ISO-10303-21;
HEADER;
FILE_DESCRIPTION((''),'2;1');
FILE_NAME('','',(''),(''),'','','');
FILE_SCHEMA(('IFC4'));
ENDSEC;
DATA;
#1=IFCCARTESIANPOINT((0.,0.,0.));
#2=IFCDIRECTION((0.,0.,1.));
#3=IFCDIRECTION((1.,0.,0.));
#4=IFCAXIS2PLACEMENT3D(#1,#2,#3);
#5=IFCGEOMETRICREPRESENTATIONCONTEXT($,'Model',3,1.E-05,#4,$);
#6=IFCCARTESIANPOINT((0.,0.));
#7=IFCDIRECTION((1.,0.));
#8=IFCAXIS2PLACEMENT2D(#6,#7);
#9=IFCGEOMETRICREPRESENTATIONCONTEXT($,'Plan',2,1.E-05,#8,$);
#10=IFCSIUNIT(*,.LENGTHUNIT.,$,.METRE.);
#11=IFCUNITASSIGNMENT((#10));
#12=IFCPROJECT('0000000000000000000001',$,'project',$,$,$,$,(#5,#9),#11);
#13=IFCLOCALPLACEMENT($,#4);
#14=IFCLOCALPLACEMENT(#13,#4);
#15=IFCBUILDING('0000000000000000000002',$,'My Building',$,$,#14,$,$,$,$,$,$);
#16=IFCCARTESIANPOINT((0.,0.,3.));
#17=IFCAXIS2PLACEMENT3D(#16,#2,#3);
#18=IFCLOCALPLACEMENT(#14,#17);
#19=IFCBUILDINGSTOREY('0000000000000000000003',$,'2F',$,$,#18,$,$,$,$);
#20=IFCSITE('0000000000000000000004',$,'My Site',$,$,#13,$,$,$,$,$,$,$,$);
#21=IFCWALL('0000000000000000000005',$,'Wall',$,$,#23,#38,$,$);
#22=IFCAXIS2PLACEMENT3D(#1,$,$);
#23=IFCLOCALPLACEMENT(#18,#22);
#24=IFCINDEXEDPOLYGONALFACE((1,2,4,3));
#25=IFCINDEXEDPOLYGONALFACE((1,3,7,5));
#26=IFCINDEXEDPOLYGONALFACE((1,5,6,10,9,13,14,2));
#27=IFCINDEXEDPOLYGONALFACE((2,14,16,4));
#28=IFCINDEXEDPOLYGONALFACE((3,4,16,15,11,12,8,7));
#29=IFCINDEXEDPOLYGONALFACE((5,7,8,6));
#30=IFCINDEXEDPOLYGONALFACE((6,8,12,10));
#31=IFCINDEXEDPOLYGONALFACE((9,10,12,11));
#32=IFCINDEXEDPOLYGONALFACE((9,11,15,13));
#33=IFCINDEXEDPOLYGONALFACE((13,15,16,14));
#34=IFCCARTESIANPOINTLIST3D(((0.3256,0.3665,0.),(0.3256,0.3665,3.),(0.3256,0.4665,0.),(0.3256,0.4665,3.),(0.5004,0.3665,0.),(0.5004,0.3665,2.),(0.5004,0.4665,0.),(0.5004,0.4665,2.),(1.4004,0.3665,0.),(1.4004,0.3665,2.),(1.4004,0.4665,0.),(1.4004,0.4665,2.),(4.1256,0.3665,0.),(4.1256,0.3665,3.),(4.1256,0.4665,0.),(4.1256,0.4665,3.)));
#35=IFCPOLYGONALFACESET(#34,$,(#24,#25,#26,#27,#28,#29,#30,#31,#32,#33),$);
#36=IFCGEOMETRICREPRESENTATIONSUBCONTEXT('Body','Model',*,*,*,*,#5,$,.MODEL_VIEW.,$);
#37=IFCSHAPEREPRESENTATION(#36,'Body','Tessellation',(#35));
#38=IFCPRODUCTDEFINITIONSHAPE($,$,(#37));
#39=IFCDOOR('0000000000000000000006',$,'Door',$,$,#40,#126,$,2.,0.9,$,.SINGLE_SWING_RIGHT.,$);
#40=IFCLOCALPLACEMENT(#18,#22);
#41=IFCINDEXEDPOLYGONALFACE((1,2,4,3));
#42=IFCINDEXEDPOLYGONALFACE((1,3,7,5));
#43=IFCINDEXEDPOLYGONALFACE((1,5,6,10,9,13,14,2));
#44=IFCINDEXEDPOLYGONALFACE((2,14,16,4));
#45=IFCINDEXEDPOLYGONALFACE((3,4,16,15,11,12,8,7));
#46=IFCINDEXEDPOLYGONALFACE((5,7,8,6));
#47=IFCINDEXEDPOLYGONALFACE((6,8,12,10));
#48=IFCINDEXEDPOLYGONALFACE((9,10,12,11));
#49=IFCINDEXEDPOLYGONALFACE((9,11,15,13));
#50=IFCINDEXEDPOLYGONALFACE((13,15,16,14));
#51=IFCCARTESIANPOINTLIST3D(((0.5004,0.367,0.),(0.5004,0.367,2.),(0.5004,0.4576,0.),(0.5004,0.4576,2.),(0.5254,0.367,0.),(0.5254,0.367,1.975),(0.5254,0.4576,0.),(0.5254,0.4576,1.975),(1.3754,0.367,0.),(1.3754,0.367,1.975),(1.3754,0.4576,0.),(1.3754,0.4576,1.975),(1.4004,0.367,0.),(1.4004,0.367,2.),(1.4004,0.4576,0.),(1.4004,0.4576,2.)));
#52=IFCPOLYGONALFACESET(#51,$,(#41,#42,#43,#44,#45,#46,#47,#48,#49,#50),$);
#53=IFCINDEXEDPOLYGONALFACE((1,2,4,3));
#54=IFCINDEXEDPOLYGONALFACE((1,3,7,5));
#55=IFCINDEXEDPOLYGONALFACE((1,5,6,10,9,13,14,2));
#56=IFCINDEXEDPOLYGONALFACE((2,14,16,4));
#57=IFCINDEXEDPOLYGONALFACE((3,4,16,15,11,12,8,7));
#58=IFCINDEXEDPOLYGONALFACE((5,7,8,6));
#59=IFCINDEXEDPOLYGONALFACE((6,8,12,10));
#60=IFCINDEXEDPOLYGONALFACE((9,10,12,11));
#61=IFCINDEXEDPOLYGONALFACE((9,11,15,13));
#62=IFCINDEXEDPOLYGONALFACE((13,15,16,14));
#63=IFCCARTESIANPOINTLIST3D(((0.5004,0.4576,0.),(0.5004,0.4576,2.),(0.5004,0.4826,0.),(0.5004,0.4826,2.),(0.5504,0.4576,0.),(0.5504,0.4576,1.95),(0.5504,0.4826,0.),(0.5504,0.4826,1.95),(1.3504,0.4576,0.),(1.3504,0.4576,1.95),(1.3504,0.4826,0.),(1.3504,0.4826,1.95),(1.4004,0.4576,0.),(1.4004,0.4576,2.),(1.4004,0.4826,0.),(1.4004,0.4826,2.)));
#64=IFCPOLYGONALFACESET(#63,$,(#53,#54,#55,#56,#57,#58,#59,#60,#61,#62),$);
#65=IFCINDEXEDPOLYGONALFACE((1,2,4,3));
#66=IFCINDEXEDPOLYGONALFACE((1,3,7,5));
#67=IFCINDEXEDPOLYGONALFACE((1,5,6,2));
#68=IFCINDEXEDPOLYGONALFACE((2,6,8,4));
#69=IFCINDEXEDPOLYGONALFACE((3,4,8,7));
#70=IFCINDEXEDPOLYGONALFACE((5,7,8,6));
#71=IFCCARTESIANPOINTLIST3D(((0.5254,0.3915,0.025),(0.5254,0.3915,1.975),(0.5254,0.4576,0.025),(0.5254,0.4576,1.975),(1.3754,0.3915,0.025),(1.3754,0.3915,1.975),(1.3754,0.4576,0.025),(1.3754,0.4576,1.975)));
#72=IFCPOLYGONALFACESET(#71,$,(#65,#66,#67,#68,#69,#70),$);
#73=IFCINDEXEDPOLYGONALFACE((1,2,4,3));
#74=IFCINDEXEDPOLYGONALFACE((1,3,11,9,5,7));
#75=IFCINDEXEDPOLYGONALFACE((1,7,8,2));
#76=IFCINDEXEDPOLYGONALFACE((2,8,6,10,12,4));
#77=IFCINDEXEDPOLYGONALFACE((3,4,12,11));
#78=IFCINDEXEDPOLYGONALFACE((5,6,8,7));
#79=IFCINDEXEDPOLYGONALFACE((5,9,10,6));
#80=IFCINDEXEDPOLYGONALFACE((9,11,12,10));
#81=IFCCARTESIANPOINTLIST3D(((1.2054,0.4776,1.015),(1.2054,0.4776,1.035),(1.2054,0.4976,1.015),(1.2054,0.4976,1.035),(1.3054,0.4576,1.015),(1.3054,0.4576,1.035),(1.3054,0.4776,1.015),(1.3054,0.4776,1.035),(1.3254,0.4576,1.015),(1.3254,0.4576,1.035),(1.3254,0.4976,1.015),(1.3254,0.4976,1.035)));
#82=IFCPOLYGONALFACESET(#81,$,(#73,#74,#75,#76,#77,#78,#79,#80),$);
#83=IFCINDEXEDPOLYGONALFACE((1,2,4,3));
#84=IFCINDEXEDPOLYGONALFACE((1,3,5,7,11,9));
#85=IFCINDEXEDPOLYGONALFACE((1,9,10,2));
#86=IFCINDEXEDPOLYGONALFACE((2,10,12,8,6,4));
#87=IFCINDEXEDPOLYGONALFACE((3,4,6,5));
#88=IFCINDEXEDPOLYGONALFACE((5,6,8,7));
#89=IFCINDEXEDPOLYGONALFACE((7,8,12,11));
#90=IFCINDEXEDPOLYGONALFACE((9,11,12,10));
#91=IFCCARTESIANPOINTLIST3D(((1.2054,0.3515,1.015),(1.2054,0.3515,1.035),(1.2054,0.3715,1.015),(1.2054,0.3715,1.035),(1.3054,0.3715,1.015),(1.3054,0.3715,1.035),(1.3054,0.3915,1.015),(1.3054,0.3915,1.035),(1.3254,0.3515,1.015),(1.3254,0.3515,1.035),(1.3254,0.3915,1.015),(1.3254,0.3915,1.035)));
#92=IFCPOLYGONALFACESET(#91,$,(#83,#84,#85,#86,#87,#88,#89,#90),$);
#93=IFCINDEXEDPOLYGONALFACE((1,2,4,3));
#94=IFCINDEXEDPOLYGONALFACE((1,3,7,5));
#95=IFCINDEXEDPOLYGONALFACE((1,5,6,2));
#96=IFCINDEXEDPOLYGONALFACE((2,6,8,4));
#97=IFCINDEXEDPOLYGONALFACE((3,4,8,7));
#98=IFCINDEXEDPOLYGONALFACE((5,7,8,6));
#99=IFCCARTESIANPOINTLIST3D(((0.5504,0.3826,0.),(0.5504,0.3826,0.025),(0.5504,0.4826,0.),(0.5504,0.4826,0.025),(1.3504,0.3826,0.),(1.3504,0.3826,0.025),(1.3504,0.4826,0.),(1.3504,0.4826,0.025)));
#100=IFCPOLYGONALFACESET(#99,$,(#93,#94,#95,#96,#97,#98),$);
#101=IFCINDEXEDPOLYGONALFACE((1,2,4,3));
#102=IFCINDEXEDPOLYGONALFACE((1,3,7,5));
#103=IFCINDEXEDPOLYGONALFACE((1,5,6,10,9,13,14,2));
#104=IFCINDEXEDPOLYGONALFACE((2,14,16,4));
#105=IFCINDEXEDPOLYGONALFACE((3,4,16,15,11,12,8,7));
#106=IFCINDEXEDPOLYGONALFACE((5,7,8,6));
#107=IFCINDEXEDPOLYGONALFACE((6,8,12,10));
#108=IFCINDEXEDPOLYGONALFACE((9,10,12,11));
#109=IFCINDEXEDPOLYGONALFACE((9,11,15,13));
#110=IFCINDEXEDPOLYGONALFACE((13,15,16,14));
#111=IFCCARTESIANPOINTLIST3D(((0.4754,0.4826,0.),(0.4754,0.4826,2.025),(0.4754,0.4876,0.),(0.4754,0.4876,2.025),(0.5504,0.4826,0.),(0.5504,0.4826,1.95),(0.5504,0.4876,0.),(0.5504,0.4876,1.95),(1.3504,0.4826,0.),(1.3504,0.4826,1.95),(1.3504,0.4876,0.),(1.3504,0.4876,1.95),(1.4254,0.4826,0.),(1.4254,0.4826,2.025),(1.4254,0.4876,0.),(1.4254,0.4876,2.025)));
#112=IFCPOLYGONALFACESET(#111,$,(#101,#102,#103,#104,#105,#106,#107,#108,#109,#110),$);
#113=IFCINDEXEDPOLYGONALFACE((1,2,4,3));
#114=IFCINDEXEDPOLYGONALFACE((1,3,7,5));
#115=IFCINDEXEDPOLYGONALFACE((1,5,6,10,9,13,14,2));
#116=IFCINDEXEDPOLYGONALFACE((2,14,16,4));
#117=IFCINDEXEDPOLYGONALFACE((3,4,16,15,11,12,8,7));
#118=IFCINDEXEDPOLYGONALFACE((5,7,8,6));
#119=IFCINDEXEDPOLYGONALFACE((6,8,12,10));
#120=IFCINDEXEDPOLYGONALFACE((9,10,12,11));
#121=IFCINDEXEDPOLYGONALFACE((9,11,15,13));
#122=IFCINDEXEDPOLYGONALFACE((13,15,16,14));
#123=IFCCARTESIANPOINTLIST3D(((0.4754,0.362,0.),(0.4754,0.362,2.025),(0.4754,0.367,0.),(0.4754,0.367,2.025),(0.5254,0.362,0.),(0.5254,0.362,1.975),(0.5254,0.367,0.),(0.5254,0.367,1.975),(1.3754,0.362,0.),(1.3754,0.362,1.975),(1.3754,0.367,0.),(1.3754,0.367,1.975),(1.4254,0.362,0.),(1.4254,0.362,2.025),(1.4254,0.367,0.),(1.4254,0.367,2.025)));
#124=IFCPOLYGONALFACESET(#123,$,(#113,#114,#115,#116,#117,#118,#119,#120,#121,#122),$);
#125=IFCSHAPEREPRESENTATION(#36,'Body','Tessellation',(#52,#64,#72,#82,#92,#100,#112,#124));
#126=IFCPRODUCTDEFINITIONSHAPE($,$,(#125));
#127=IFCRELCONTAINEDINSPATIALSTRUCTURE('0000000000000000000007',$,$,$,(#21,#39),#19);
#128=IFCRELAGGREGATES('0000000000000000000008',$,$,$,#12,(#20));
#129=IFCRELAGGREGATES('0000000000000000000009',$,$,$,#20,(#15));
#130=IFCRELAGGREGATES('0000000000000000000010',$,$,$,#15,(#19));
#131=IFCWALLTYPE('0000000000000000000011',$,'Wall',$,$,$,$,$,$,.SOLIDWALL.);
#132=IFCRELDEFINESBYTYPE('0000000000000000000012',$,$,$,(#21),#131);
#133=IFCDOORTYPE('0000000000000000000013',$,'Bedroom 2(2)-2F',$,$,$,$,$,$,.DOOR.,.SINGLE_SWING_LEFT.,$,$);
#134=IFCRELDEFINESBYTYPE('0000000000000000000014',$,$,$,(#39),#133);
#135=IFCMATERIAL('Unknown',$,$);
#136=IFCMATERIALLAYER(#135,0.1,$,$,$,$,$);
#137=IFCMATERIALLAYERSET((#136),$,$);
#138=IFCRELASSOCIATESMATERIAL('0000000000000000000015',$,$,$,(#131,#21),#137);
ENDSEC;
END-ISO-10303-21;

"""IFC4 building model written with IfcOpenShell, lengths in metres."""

from ifc_helpers import new_model, entity, si_unit, frame, origin_with_axes, origin_2d_with_axis, place, context, subcontext, project, spatial, line, indexed_curve, outline, extrude, shape, source, transform, mapped, material, layer, layer_set, layer_usage, type_object, type_shapes, element, fill, save


model = new_model("IFC4")

# Units and contexts
model_context = context("Model", 3, precision=1e-05, world=origin_with_axes())
plan_context = context("Plan", 2, precision=1e-05, world=origin_2d_with_axis())
body_context_1 = subcontext(model_context, "Body", "Model", "MODEL_VIEW")
body_context_2 = subcontext(plan_context, "Body", "Plan", "PLAN_VIEW")
ifc_project = project(units=[si_unit("LENGTHUNIT", "METRE")], contexts=[model_context, plan_context])

# Site, building, storey
site_placement = place(None, origin_with_axes())
site = spatial("IfcSite", under=ifc_project, at=site_placement, Name="My Site")
building_placement = place(site_placement, origin_with_axes())
building = spatial("IfcBuilding", under=site, at=building_placement, Name="My Building")
storey_placement = place(building_placement, frame((0.0, 0.0, 3.0), z_axis=(0.0, 0.0, 1.0), x_axis=(1.0, 0.0, 0.0)))
storey = spatial("IfcBuildingStorey", under=building, at=storey_placement, Name="2F")

# Shared definitions
ifc_material = material(Name="Unknown")

# Shared definitions
ifc_layer_1 = layer(ifc_material, 0.1)
ifc_layer_set_1 = layer_set([ifc_layer_1])
wall_type = type_object("IfcWallType", Name="Wall", PredefinedType="SOLIDWALL", material=ifc_layer_set_1)

# Wall, opening, door
ifc_layer_usage_1 = layer_usage(ifc_layer_set_1, "AXIS2", "POSITIVE", 0.0)
wall_1_placement = place(storey_placement, frame((4.1256, 0.4665, 0.0), z_axis=(0.0, 0.0, 1.0), x_axis=(-1.0, 0.0, 0.0)))
wall_1 = element("IfcWall", 1, at=wall_1_placement, inside=storey, type_object=wall_type, material=ifc_layer_usage_1, Name="Wall", context=body_context_1, shape_type="SweptSolid", body=[
    extrude(outline(indexed_curve([(0.0, 0.0), (0.0, 0.1), (3.8, 0.1), (3.8, 0.0)], segments=[line(1, 2, 3, 4, 1)])), origin_with_axes(), (0.0, 0.0, 1.0), 3.0),
])
shared_shape_1 = source(origin_with_axes(), body_context_1, "Body", "SweptSolid", [
    extrude(outline(indexed_curve([(0.0, 0.0), (0.9, 0.0), (0.9, 2.0), (0.0, 2.0)], segments=[line(1, 2, 3, 4, 1)])), frame((0.0, -0.6, 0.0), z_axis=(0.0, -1.0, 0.0), x_axis=(1.0, 0.0, 0.0)), (0.0, 0.0, -1.0), 1.2),
])
opening_1_placement = place(wall_1_placement, frame((2.7252, -0.0161, 0.0), z_axis=(0.0, 0.0, 1.0), x_axis=(1.0, 0.0, 0.0)))
opening_1 = element("IfcOpeningElement", 2, at=opening_1_placement, cuts=wall_1, PredefinedType="OPENING", context=body_context_1, shape_type="MappedRepresentation", body=[
    mapped(shared_shape_1, transform((0.0, 0.0, 0.0), x_axis=(1.0, 0.0, 0.0), y_axis=(0.0, 1.0, 0.0), z_axis=(0.0, 0.0, 1.0), scale=1.0)),
])
door_type_1 = type_object("IfcDoorType", Name="Bedroom 2(2)-2F", OperationType="SINGLE_SWING_LEFT", PredefinedType="DOOR")
shared_shape_2 = source(origin_with_axes(), body_context_1, "Body", "SweptSolid", [
    extrude(outline(indexed_curve([(0.0, 0.0), (0.0, 2.0), (0.9, 2.0), (0.9, 0.0), (0.875, 0.0), (0.875, 1.975), (0.025, 1.975), (0.025, 0.0)], segments=[line(1, 2, 3, 4, 5, 6, 7, 8, 1)])), frame((0.0, 0.025, 0.0), z_axis=(0.0, -1.0, 0.0), x_axis=(1.0, 0.0, 0.0)), (0.0, 0.0, -1.0), 0.0906),
    extrude(outline(indexed_curve([(0.0, 0.0), (0.0, 2.0), (0.9, 2.0), (0.9, 0.0), (0.85, 0.0), (0.85, 1.95), (0.05, 1.95), (0.05, 0.0)], segments=[line(1, 2, 3, 4, 5, 6, 7, 8, 1)])), frame((0.0, 0.0, 0.0), z_axis=(0.0, -1.0, 0.0), x_axis=(1.0, 0.0, 0.0)), (0.0, 0.0, -1.0), 0.025),
    extrude(outline(indexed_curve([(0.0, 0.0), (0.85, 0.0), (0.85, 0.0661), (0.0, 0.0661)], segments=[line(1, 2, 3, 4, 1)])), frame((0.025, 0.025, 0.025), z_axis=(0.0, 0.0, 1.0), x_axis=(1.0, 0.0, 0.0)), (0.0, 0.0, 1.0), 1.95),
    extrude(outline(indexed_curve([(0.0, 0.0), (0.0, -0.04), (0.12, -0.04), (0.12, -0.02), (0.02, -0.02), (0.02, 0.0)], segments=[line(1, 2, 3, 4, 5, 6, 1)])), frame((0.075, 0.025, 1.015), z_axis=(0.0, 0.0, 1.0), x_axis=(1.0, 0.0, 0.0)), (0.0, 0.0, 1.0), 0.02),
    extrude(outline(indexed_curve([(0.0, 0.0), (0.0, 0.04), (0.12, 0.04), (0.12, 0.02), (0.02, 0.02), (0.02, 0.0)], segments=[line(1, 2, 3, 4, 5, 6, 1)])), frame((0.075, 0.0911, 1.015), z_axis=(0.0, 0.0, 1.0), x_axis=(1.0, 0.0, 0.0)), (0.0, 0.0, 1.0), 0.02),
    extrude(outline(indexed_curve([(0.0, 0.0), (0.8, 0.0), (0.8, 0.1), (0.0, 0.1)], segments=[line(1, 2, 3, 4, 1)])), frame((0.05, 0.0, 0.0), z_axis=(0.0, 0.0, 1.0), x_axis=(1.0, 0.0, 0.0)), (0.0, 0.0, 1.0), 0.025),
    extrude(outline(indexed_curve([(0.0, 0.0), (0.0, 2.025), (0.95, 2.025), (0.95, 0.0), (0.875, 0.0), (0.875, 1.95), (0.075, 1.95), (0.075, 0.0)], segments=[line(1, 2, 3, 4, 5, 6, 7, 8, 1)])), frame((-0.025, -0.005, 0.0), z_axis=(0.0, -1.0, 0.0), x_axis=(1.0, 0.0, 0.0)), (0.0, 0.0, -1.0), 0.005),
    extrude(outline(indexed_curve([(0.0, 0.0), (0.0, 2.025), (0.95, 2.025), (0.95, 0.0), (0.9, 0.0), (0.9, 1.975), (0.05, 1.975), (0.05, 0.0)], segments=[line(1, 2, 3, 4, 5, 6, 7, 8, 1)])), frame((-0.025, 0.1156, 0.0), z_axis=(0.0, -1.0, 0.0), x_axis=(1.0, 0.0, 0.0)), (0.0, 0.0, -1.0), 0.005),
])
shared_shape_3 = source(origin_with_axes(), body_context_2, "Body", "Curve2D", [
    entity("IfcIndexedPolyCurve", entity("IfcCartesianPointList2D", [[0.0, 0.0], [0.0, 0.1156], [0.025, 0.1156], [0.025, 0.025], [0.05, 0.025], [0.05, 0.0]]), [entity("IfcLineIndex", [1, 2, 3, 4, 5, 6, 1])]),
    entity("IfcIndexedPolyCurve", entity("IfcCartesianPointList2D", [[0.9, 0.0], [0.9, 0.1156], [0.875, 0.1156], [0.875, 0.025], [0.85, 0.025], [0.85, 0.0]]), [entity("IfcLineIndex", [1, 2, 3, 4, 5, 6, 1])]),
    entity("IfcTrimmedCurve", entity("IfcEllipse", entity("IfcAxis2Placement2D", entity("IfcCartesianPoint", [0.8089, 0.1156]), entity("IfcDirection", [1.0, 0.0])), 0.7839, 0.85), [entity("IfcCartesianPoint", [0.8089, 0.9656])], [entity("IfcCartesianPoint", [0.025, 0.1156])], True, "CARTESIAN"),
    entity("IfcIndexedPolyCurve", entity("IfcCartesianPointList2D", [[0.875, 0.1156], [0.8089, 0.1156], [0.8089, 0.9656], [0.875, 0.9656]]), [entity("IfcLineIndex", [1, 2, 3, 4, 1])]),
])
type_shapes(door_type_1, [shared_shape_2, shared_shape_3])
door_1_placement = place(opening_1_placement, frame((0.0, 0.0, 0.0), z_axis=(0.0, 0.0, 1.0), x_axis=(1.0, 0.0, 0.0)))
door_1 = element("IfcDoor", 3, at=door_1_placement, inside=storey, type_object=door_type_1, Name="Door", OperationType="SINGLE_SWING_RIGHT", OverallHeight=2.0, OverallWidth=0.9, shapes=[
    shape(body_context_1, "Body", "MappedRepresentation", [mapped(shared_shape_2, transform((0.0, 0.0, 0.0), x_axis=(1.0, 0.0, 0.0), y_axis=(0.0, 1.0, 0.0), z_axis=(0.0, 0.0, 1.0), scale=1.0))]),
    shape(body_context_2, "Body", "MappedRepresentation", [mapped(shared_shape_3, transform((0.0, 0.0, 0.0), x_axis=(1.0, 0.0, 0.0), y_axis=(0.0, 1.0, 0.0), z_axis=(0.0, 0.0, 1.0), scale=1.0))]),
])
fill(opening_1, door_1)

save(model, "model.ifc")
